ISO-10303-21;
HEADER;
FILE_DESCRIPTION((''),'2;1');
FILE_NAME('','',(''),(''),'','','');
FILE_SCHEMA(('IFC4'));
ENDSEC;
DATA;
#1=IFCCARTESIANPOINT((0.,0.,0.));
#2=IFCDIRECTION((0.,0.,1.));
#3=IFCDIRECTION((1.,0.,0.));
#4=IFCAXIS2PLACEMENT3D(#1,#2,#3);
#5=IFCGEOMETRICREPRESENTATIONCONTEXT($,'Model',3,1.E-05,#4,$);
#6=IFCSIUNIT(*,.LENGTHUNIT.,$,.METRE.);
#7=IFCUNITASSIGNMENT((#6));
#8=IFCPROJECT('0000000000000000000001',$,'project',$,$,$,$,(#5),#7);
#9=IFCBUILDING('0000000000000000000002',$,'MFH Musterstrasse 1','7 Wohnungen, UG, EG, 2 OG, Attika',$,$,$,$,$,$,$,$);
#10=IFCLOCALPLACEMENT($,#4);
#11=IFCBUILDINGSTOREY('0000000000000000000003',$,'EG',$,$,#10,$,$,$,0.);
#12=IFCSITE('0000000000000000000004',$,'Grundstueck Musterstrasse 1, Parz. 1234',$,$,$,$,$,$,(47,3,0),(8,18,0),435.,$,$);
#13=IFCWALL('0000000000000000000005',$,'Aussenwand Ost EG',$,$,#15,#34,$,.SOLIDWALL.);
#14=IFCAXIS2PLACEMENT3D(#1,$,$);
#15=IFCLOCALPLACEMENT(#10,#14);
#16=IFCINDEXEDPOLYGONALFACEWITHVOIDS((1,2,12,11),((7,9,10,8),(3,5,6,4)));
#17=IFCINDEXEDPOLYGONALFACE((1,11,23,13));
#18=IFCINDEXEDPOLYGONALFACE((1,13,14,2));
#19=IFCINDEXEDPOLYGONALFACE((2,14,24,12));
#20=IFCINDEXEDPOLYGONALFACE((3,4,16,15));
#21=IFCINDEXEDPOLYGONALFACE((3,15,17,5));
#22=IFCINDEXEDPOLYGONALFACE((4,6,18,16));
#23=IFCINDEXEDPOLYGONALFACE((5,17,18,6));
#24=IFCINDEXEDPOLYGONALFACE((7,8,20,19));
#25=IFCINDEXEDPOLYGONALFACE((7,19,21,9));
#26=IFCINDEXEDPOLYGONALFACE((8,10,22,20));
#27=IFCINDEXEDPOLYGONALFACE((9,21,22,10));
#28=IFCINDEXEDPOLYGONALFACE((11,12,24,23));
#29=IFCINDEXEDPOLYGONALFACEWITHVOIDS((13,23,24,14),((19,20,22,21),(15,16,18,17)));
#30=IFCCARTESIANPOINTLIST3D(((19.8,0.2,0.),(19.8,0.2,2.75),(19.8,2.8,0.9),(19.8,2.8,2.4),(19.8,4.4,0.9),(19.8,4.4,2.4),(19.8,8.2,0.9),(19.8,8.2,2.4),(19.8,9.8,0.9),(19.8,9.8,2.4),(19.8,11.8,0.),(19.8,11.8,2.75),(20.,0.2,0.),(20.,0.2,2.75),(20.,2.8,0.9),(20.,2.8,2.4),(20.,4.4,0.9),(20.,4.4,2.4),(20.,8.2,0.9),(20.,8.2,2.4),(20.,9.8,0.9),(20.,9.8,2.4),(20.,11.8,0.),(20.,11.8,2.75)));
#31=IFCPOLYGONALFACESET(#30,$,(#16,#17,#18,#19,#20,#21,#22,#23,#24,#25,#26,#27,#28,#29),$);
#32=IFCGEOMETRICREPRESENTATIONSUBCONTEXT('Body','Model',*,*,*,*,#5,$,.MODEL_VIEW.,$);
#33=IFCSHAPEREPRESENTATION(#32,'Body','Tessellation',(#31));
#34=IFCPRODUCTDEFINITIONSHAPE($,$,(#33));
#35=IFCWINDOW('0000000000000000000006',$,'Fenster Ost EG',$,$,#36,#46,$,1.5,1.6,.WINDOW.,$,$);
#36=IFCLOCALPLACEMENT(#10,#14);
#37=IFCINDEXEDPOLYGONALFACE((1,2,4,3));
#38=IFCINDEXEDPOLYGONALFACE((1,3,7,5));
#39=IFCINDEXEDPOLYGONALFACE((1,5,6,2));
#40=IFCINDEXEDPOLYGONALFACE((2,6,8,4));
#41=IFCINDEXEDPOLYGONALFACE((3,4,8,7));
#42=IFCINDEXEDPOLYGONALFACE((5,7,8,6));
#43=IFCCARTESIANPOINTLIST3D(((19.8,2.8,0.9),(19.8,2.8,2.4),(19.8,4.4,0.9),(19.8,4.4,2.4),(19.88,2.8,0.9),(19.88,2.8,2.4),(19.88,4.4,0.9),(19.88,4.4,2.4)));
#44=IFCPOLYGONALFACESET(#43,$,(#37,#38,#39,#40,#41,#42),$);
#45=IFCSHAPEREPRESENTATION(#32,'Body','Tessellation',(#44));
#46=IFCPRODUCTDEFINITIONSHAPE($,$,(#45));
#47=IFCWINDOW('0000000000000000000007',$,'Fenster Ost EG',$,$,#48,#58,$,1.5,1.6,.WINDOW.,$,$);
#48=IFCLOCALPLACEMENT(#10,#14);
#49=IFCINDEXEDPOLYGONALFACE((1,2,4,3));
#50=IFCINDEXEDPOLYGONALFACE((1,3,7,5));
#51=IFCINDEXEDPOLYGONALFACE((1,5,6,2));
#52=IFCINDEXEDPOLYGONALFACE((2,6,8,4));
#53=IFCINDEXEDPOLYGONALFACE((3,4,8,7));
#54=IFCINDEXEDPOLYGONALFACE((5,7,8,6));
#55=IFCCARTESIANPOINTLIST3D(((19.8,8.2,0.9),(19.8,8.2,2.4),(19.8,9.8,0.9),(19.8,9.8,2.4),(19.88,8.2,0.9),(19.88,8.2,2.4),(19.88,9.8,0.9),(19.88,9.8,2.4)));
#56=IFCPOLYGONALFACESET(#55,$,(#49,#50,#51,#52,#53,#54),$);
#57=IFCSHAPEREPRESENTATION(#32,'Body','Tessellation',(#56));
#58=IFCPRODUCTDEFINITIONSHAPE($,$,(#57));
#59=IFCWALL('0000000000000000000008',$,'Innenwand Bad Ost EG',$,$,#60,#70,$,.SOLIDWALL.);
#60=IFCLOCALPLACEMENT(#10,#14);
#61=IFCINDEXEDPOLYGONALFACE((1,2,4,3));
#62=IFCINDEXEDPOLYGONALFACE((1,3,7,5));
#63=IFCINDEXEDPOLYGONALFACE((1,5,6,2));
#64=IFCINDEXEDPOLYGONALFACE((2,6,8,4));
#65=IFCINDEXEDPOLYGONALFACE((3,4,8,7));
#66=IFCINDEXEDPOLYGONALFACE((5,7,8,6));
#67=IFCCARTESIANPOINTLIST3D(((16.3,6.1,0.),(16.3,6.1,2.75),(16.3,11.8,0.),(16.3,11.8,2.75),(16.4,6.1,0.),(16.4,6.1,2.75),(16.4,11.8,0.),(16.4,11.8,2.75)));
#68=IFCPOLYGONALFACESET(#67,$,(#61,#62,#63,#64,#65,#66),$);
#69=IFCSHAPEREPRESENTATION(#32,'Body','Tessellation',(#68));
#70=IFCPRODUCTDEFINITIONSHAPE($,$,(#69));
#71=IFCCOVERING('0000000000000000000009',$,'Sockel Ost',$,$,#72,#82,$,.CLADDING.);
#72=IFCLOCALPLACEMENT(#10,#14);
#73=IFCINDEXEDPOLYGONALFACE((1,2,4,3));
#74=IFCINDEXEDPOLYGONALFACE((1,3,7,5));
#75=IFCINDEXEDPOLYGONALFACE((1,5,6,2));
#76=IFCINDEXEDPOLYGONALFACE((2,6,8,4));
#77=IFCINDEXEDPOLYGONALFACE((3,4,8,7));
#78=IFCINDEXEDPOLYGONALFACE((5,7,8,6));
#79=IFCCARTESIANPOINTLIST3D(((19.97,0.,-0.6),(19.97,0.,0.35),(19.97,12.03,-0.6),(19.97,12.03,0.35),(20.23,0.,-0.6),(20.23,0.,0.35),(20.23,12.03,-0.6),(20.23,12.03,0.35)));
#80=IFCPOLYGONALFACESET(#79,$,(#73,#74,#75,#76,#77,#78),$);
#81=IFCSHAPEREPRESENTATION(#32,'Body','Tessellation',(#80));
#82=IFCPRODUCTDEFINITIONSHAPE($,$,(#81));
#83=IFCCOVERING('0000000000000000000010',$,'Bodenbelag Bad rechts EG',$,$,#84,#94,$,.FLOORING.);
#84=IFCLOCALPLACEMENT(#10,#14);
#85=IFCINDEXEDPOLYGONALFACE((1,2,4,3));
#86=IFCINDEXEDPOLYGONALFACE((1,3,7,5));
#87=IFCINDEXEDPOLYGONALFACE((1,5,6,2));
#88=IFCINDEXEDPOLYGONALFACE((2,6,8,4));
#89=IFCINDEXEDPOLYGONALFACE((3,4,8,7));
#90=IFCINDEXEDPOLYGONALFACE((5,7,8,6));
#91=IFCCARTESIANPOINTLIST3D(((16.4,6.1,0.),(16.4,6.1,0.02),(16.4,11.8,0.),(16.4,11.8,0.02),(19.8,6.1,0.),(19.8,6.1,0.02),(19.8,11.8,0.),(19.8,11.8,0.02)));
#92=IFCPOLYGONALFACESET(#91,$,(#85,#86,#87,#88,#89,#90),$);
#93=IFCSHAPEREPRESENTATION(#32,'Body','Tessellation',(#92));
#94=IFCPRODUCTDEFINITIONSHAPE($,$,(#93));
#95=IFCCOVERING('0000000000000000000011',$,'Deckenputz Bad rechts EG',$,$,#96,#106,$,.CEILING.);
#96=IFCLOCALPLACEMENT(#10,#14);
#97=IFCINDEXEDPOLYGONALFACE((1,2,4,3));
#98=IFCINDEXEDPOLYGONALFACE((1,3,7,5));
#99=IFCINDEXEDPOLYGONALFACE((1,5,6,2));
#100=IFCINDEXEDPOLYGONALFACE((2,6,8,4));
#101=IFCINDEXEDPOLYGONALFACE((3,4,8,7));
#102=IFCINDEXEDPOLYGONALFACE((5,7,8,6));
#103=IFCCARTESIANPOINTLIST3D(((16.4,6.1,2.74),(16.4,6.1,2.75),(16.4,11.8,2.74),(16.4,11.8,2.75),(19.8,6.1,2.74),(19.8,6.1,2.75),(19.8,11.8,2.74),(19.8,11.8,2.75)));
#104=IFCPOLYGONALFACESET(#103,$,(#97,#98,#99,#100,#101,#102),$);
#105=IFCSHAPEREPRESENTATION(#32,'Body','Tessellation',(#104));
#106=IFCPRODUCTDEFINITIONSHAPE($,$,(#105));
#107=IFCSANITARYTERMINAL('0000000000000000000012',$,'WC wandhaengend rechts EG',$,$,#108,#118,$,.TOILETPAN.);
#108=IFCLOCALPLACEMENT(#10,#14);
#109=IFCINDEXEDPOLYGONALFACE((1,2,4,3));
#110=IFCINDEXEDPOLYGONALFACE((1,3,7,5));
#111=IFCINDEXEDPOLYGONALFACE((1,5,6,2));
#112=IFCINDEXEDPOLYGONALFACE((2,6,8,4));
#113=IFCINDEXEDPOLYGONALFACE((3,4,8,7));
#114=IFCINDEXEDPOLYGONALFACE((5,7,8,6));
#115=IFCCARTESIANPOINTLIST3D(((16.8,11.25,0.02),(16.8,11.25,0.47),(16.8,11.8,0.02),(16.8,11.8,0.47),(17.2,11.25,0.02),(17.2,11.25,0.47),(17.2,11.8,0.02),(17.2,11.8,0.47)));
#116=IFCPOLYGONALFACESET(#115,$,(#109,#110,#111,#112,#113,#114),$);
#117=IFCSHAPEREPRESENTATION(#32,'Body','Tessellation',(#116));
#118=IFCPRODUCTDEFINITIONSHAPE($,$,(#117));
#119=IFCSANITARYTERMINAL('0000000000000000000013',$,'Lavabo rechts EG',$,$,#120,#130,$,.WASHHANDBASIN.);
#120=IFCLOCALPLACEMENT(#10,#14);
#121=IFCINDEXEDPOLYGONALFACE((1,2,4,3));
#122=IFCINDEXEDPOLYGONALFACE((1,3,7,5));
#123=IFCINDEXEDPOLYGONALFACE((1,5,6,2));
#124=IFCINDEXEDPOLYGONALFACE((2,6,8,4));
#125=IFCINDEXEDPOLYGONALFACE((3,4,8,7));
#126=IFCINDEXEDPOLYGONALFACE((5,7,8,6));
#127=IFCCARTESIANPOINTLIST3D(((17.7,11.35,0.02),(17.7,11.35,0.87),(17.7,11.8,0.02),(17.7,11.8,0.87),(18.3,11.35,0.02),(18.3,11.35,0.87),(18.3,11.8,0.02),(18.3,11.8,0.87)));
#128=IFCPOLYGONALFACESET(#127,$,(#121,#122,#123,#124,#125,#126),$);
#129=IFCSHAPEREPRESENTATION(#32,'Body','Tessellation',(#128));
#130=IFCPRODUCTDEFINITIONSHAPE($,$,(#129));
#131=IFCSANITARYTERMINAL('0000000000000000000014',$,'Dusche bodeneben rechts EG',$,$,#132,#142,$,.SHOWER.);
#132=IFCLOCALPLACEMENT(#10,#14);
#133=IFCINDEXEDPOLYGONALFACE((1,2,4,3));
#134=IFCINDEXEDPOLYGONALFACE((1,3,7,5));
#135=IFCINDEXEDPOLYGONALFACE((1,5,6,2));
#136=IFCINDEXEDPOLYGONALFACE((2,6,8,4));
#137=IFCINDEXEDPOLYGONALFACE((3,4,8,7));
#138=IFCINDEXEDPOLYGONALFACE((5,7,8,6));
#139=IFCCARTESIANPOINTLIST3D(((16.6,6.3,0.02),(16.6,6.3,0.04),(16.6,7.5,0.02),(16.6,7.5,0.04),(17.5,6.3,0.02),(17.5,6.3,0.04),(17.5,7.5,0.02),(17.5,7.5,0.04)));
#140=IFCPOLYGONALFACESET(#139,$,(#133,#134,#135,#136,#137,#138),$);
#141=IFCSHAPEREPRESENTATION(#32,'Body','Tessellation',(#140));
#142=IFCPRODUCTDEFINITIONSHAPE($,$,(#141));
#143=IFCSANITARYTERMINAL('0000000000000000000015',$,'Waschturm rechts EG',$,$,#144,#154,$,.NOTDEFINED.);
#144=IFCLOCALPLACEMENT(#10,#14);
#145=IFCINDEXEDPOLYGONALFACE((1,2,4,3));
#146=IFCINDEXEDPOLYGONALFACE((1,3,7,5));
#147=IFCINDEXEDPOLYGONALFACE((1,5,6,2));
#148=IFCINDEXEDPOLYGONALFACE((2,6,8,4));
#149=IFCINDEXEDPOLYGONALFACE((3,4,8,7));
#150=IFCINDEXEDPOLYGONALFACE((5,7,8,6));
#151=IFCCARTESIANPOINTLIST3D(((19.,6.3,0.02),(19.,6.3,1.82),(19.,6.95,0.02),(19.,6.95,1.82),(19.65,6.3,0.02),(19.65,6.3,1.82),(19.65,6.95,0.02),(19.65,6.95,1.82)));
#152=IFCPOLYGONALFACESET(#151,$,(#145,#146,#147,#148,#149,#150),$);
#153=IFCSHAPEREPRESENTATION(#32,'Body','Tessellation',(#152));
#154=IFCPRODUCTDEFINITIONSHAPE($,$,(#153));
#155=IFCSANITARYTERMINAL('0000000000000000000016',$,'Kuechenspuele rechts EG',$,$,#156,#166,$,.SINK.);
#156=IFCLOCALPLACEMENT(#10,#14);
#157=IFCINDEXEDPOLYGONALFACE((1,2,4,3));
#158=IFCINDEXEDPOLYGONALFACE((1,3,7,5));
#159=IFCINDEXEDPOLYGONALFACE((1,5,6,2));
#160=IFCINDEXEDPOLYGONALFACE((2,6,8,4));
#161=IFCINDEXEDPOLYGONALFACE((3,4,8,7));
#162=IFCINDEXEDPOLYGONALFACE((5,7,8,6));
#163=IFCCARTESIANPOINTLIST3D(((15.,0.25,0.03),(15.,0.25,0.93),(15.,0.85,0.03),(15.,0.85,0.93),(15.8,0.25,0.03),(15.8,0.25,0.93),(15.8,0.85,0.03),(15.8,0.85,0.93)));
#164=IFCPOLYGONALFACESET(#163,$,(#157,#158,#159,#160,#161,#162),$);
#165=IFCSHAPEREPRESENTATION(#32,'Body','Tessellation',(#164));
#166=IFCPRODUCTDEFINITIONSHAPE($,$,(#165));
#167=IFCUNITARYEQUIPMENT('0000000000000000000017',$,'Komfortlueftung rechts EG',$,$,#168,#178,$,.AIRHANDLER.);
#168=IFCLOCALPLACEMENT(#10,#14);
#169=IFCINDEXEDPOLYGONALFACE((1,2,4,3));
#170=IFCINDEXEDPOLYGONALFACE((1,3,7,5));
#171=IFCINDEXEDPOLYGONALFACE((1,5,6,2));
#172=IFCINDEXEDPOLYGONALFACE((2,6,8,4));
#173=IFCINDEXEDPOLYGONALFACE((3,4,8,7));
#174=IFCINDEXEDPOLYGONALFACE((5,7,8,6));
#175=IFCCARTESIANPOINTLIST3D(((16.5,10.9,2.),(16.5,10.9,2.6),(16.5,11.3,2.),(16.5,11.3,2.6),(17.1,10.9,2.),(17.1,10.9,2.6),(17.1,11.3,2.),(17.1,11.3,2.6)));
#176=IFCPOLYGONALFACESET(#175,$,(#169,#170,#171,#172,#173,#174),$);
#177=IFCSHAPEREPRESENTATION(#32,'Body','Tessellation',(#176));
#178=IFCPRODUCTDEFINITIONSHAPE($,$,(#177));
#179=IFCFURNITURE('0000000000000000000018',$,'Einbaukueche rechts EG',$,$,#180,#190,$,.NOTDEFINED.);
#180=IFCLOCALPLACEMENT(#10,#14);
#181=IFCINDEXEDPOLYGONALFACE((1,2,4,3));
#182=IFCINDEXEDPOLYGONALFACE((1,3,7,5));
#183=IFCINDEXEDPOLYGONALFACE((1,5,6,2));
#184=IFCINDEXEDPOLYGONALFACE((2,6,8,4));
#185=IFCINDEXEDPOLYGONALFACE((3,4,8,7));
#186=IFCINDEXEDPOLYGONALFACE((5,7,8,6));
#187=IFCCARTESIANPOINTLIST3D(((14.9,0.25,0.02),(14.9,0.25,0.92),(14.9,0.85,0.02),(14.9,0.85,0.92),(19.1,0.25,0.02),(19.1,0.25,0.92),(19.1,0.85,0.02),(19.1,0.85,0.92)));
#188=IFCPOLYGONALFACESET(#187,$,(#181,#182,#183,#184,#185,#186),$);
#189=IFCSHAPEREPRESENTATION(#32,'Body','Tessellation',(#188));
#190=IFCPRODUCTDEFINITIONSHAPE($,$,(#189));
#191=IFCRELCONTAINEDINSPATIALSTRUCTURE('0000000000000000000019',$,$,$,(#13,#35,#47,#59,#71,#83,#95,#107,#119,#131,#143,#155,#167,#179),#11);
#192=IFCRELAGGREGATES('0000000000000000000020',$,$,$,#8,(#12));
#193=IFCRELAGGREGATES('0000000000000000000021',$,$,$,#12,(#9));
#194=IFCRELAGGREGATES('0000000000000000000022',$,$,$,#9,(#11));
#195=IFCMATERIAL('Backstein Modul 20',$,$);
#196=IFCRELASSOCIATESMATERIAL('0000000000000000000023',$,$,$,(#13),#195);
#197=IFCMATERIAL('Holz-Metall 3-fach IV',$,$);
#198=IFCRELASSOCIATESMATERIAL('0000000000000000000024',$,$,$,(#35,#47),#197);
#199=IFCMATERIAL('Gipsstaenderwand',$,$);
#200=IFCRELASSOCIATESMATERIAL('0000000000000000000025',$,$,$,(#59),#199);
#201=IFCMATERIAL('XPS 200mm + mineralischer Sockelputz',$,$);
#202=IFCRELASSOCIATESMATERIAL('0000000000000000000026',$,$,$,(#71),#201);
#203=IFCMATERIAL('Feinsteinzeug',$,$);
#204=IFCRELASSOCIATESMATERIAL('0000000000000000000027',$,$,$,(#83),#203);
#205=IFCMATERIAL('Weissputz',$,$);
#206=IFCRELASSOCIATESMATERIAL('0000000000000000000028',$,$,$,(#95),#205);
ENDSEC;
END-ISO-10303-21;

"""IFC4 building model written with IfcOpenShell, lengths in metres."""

from ifc_helpers import new_model, si_unit, frame, frame_2d, origin_with_axes, place, context, subcontext, project, spatial, rectangle, extrude, material, element, fill, save


model = new_model("IFC4")

# Units and contexts
model_context = context("Model", 3, precision=1e-05, world=origin_with_axes())
body_context = subcontext(model_context, "Body", "Model", "MODEL_VIEW")
ifc_project = project(units=[si_unit("LENGTHUNIT", "METRE")], contexts=[model_context])

# Site, building, storey
site = spatial("IfcSite", under=ifc_project, Name="Grundstueck Musterstrasse 1, Parz. 1234", RefLatitude=(47, 3, 0), RefLongitude=(8, 18, 0), RefElevation=435.0)
building = spatial("IfcBuilding", under=site, Name="MFH Musterstrasse 1", Description="7 Wohnungen, UG, EG, 2 OG, Attika")
storey_placement = place(None, origin_with_axes())
storey = spatial("IfcBuildingStorey", under=building, at=storey_placement, Name="EG", Elevation=0.0)

# Wall, openings, windows
ifc_material_1 = material(Name="Backstein Modul 20")
wall_1_placement = place(storey_placement, frame((19.8, 0.2, 0.0), z_axis=(0.0, 0.0, 1.0), x_axis=(1.0, 0.0, 0.0)))
wall_1 = element("IfcWall", 1, at=wall_1_placement, inside=storey, material=ifc_material_1, Name="Aussenwand Ost EG", PredefinedType="SOLIDWALL", context=body_context, shape_type="SweptSolid", body=[
    extrude(rectangle(XDim=0.2, YDim=11.6, at=frame_2d((0.1, 5.8))), origin_with_axes(), (0.0, 0.0, 1.0), 2.75),
])
opening_1_placement = place(wall_1_placement, frame((-0.01, 2.6, 0.9), z_axis=(0.0, 0.0, 1.0), x_axis=(1.0, 0.0, 0.0)))
opening_1 = element("IfcOpeningElement", 2, at=opening_1_placement, cuts=wall_1, context=body_context, shape_type="SweptSolid", body=[
    extrude(rectangle(XDim=0.42, YDim=1.6, at=frame_2d((0.21, 0.8))), origin_with_axes(), (0.0, 0.0, 1.0), 1.5),
])
opening_2_placement = place(wall_1_placement, frame((-0.01, 8.0, 0.9), z_axis=(0.0, 0.0, 1.0), x_axis=(1.0, 0.0, 0.0)))
opening_2 = element("IfcOpeningElement", 3, at=opening_2_placement, cuts=wall_1, context=body_context, shape_type="SweptSolid", body=[
    extrude(rectangle(XDim=0.42, YDim=1.6, at=frame_2d((0.21, 0.8))), origin_with_axes(), (0.0, 0.0, 1.0), 1.5),
])
ifc_material_2 = material(Name="Holz-Metall 3-fach IV")
window_1_placement = place(storey_placement, frame((19.8, 2.8, 0.9), z_axis=(0.0, 0.0, 1.0), x_axis=(1.0, 0.0, 0.0)))
window_1 = element("IfcWindow", 4, at=window_1_placement, inside=storey, material=ifc_material_2, Name="Fenster Ost EG", OverallHeight=1.5, OverallWidth=1.6, PredefinedType="WINDOW", context=body_context, shape_type="SweptSolid", body=[
    extrude(rectangle(XDim=0.08, YDim=1.6, at=frame_2d((0.04, 0.8))), origin_with_axes(), (0.0, 0.0, 1.0), 1.5),
])
fill(opening_1, window_1)
window_2_placement = place(storey_placement, frame((19.8, 8.2, 0.9), z_axis=(0.0, 0.0, 1.0), x_axis=(1.0, 0.0, 0.0)))
window_2 = element("IfcWindow", 5, at=window_2_placement, inside=storey, material=ifc_material_2, Name="Fenster Ost EG", OverallHeight=1.5, OverallWidth=1.6, PredefinedType="WINDOW", context=body_context, shape_type="SweptSolid", body=[
    extrude(rectangle(XDim=0.08, YDim=1.6, at=frame_2d((0.04, 0.8))), origin_with_axes(), (0.0, 0.0, 1.0), 1.5),
])
fill(opening_2, window_2)

# Wall
ifc_material_3 = material(Name="Gipsstaenderwand")
wall_2_placement = place(storey_placement, frame((16.3, 6.1, 0.0), z_axis=(0.0, 0.0, 1.0), x_axis=(1.0, 0.0, 0.0)))
element("IfcWall", 6, at=wall_2_placement, inside=storey, material=ifc_material_3, Name="Innenwand Bad Ost EG", PredefinedType="SOLIDWALL", context=body_context, shape_type="SweptSolid", body=[
    extrude(rectangle(XDim=0.1, YDim=5.7, at=frame_2d((0.05, 2.85))), origin_with_axes(), (0.0, 0.0, 1.0), 2.75),
])

# Covering
ifc_material_4 = material(Name="XPS 200mm + mineralischer Sockelputz")
covering_1_placement = place(storey_placement, frame((19.97, 0.0, -0.6), z_axis=(0.0, 0.0, 1.0), x_axis=(1.0, 0.0, 0.0)))
element("IfcCovering", 7, at=covering_1_placement, inside=storey, material=ifc_material_4, Name="Sockel Ost", PredefinedType="CLADDING", context=body_context, shape_type="SweptSolid", body=[
    extrude(rectangle(XDim=0.26, YDim=12.03, at=frame_2d((0.13, 6.015))), origin_with_axes(), (0.0, 0.0, 1.0), 0.95),
])

# Coverings
ifc_material_5 = material(Name="Feinsteinzeug")
covering_2_placement = place(storey_placement, frame((16.4, 6.1, 0.0), z_axis=(0.0, 0.0, 1.0), x_axis=(1.0, 0.0, 0.0)))
element("IfcCovering", 8, at=covering_2_placement, inside=storey, material=ifc_material_5, Name="Bodenbelag Bad rechts EG", PredefinedType="FLOORING", context=body_context, shape_type="SweptSolid", body=[
    extrude(rectangle(XDim=3.4, YDim=5.7, at=frame_2d((1.7, 2.85))), origin_with_axes(), (0.0, 0.0, 1.0), 0.02),
])
ifc_material_6 = material(Name="Weissputz")
covering_3_placement = place(storey_placement, frame((16.4, 6.1, 2.74), z_axis=(0.0, 0.0, 1.0), x_axis=(1.0, 0.0, 0.0)))
element("IfcCovering", 9, at=covering_3_placement, inside=storey, material=ifc_material_6, Name="Deckenputz Bad rechts EG", PredefinedType="CEILING", context=body_context, shape_type="SweptSolid", body=[
    extrude(rectangle(XDim=3.4, YDim=5.7, at=frame_2d((1.7, 2.85))), origin_with_axes(), (0.0, 0.0, 1.0), 0.01),
])

# Sanitary terminals
sanitary_terminal_1_placement = place(storey_placement, frame((16.8, 11.25, 0.02), z_axis=(0.0, 0.0, 1.0), x_axis=(1.0, 0.0, 0.0)))
element("IfcSanitaryTerminal", 10, at=sanitary_terminal_1_placement, inside=storey, Name="WC wandhaengend rechts EG", PredefinedType="TOILETPAN", context=body_context, shape_type="SweptSolid", body=[
    extrude(rectangle(XDim=0.4, YDim=0.55, at=frame_2d((0.2, 0.275))), origin_with_axes(), (0.0, 0.0, 1.0), 0.45),
])
sanitary_terminal_2_placement = place(storey_placement, frame((17.7, 11.35, 0.02), z_axis=(0.0, 0.0, 1.0), x_axis=(1.0, 0.0, 0.0)))
element("IfcSanitaryTerminal", 11, at=sanitary_terminal_2_placement, inside=storey, Name="Lavabo rechts EG", PredefinedType="WASHHANDBASIN", context=body_context, shape_type="SweptSolid", body=[
    extrude(rectangle(XDim=0.6, YDim=0.45, at=frame_2d((0.3, 0.225))), origin_with_axes(), (0.0, 0.0, 1.0), 0.85),
])
sanitary_terminal_3_placement = place(storey_placement, frame((16.6, 6.3, 0.02), z_axis=(0.0, 0.0, 1.0), x_axis=(1.0, 0.0, 0.0)))
element("IfcSanitaryTerminal", 12, at=sanitary_terminal_3_placement, inside=storey, Name="Dusche bodeneben rechts EG", PredefinedType="SHOWER", context=body_context, shape_type="SweptSolid", body=[
    extrude(rectangle(XDim=0.9, YDim=1.2, at=frame_2d((0.45, 0.6))), origin_with_axes(), (0.0, 0.0, 1.0), 0.02),
])
sanitary_terminal_4_placement = place(storey_placement, frame((19.0, 6.3, 0.02), z_axis=(0.0, 0.0, 1.0), x_axis=(1.0, 0.0, 0.0)))
element("IfcSanitaryTerminal", 13, at=sanitary_terminal_4_placement, inside=storey, Name="Waschturm rechts EG", PredefinedType="NOTDEFINED", context=body_context, shape_type="SweptSolid", body=[
    extrude(rectangle(XDim=0.65, YDim=0.65, at=frame_2d((0.325, 0.325))), origin_with_axes(), (0.0, 0.0, 1.0), 1.8),
])
sanitary_terminal_5_placement = place(storey_placement, frame((15.0, 0.25, 0.03), z_axis=(0.0, 0.0, 1.0), x_axis=(1.0, 0.0, 0.0)))
element("IfcSanitaryTerminal", 14, at=sanitary_terminal_5_placement, inside=storey, Name="Kuechenspuele rechts EG", PredefinedType="SINK", context=body_context, shape_type="SweptSolid", body=[
    extrude(rectangle(XDim=0.8, YDim=0.6, at=frame_2d((0.4, 0.3))), origin_with_axes(), (0.0, 0.0, 1.0), 0.9),
])

# Unitary equipment
unitary_equipment_placement = place(storey_placement, frame((16.5, 10.9, 2.0), z_axis=(0.0, 0.0, 1.0), x_axis=(1.0, 0.0, 0.0)))
element("IfcUnitaryEquipment", 15, at=unitary_equipment_placement, inside=storey, Name="Komfortlueftung rechts EG", PredefinedType="AIRHANDLER", context=body_context, shape_type="SweptSolid", body=[
    extrude(rectangle(XDim=0.6, YDim=0.4, at=frame_2d((0.3, 0.2))), origin_with_axes(), (0.0, 0.0, 1.0), 0.6),
])

# Furniture
furniture_1_placement = place(storey_placement, frame((14.9, 0.25, 0.02), z_axis=(0.0, 0.0, 1.0), x_axis=(1.0, 0.0, 0.0)))
element("IfcFurniture", 16, at=furniture_1_placement, inside=storey, Name="Einbaukueche rechts EG", PredefinedType="NOTDEFINED", context=body_context, shape_type="SweptSolid", body=[
    extrude(rectangle(XDim=4.2, YDim=0.6, at=frame_2d((2.1, 0.3))), origin_with_axes(), (0.0, 0.0, 1.0), 0.9),
])

save(model, "model.ifc")
